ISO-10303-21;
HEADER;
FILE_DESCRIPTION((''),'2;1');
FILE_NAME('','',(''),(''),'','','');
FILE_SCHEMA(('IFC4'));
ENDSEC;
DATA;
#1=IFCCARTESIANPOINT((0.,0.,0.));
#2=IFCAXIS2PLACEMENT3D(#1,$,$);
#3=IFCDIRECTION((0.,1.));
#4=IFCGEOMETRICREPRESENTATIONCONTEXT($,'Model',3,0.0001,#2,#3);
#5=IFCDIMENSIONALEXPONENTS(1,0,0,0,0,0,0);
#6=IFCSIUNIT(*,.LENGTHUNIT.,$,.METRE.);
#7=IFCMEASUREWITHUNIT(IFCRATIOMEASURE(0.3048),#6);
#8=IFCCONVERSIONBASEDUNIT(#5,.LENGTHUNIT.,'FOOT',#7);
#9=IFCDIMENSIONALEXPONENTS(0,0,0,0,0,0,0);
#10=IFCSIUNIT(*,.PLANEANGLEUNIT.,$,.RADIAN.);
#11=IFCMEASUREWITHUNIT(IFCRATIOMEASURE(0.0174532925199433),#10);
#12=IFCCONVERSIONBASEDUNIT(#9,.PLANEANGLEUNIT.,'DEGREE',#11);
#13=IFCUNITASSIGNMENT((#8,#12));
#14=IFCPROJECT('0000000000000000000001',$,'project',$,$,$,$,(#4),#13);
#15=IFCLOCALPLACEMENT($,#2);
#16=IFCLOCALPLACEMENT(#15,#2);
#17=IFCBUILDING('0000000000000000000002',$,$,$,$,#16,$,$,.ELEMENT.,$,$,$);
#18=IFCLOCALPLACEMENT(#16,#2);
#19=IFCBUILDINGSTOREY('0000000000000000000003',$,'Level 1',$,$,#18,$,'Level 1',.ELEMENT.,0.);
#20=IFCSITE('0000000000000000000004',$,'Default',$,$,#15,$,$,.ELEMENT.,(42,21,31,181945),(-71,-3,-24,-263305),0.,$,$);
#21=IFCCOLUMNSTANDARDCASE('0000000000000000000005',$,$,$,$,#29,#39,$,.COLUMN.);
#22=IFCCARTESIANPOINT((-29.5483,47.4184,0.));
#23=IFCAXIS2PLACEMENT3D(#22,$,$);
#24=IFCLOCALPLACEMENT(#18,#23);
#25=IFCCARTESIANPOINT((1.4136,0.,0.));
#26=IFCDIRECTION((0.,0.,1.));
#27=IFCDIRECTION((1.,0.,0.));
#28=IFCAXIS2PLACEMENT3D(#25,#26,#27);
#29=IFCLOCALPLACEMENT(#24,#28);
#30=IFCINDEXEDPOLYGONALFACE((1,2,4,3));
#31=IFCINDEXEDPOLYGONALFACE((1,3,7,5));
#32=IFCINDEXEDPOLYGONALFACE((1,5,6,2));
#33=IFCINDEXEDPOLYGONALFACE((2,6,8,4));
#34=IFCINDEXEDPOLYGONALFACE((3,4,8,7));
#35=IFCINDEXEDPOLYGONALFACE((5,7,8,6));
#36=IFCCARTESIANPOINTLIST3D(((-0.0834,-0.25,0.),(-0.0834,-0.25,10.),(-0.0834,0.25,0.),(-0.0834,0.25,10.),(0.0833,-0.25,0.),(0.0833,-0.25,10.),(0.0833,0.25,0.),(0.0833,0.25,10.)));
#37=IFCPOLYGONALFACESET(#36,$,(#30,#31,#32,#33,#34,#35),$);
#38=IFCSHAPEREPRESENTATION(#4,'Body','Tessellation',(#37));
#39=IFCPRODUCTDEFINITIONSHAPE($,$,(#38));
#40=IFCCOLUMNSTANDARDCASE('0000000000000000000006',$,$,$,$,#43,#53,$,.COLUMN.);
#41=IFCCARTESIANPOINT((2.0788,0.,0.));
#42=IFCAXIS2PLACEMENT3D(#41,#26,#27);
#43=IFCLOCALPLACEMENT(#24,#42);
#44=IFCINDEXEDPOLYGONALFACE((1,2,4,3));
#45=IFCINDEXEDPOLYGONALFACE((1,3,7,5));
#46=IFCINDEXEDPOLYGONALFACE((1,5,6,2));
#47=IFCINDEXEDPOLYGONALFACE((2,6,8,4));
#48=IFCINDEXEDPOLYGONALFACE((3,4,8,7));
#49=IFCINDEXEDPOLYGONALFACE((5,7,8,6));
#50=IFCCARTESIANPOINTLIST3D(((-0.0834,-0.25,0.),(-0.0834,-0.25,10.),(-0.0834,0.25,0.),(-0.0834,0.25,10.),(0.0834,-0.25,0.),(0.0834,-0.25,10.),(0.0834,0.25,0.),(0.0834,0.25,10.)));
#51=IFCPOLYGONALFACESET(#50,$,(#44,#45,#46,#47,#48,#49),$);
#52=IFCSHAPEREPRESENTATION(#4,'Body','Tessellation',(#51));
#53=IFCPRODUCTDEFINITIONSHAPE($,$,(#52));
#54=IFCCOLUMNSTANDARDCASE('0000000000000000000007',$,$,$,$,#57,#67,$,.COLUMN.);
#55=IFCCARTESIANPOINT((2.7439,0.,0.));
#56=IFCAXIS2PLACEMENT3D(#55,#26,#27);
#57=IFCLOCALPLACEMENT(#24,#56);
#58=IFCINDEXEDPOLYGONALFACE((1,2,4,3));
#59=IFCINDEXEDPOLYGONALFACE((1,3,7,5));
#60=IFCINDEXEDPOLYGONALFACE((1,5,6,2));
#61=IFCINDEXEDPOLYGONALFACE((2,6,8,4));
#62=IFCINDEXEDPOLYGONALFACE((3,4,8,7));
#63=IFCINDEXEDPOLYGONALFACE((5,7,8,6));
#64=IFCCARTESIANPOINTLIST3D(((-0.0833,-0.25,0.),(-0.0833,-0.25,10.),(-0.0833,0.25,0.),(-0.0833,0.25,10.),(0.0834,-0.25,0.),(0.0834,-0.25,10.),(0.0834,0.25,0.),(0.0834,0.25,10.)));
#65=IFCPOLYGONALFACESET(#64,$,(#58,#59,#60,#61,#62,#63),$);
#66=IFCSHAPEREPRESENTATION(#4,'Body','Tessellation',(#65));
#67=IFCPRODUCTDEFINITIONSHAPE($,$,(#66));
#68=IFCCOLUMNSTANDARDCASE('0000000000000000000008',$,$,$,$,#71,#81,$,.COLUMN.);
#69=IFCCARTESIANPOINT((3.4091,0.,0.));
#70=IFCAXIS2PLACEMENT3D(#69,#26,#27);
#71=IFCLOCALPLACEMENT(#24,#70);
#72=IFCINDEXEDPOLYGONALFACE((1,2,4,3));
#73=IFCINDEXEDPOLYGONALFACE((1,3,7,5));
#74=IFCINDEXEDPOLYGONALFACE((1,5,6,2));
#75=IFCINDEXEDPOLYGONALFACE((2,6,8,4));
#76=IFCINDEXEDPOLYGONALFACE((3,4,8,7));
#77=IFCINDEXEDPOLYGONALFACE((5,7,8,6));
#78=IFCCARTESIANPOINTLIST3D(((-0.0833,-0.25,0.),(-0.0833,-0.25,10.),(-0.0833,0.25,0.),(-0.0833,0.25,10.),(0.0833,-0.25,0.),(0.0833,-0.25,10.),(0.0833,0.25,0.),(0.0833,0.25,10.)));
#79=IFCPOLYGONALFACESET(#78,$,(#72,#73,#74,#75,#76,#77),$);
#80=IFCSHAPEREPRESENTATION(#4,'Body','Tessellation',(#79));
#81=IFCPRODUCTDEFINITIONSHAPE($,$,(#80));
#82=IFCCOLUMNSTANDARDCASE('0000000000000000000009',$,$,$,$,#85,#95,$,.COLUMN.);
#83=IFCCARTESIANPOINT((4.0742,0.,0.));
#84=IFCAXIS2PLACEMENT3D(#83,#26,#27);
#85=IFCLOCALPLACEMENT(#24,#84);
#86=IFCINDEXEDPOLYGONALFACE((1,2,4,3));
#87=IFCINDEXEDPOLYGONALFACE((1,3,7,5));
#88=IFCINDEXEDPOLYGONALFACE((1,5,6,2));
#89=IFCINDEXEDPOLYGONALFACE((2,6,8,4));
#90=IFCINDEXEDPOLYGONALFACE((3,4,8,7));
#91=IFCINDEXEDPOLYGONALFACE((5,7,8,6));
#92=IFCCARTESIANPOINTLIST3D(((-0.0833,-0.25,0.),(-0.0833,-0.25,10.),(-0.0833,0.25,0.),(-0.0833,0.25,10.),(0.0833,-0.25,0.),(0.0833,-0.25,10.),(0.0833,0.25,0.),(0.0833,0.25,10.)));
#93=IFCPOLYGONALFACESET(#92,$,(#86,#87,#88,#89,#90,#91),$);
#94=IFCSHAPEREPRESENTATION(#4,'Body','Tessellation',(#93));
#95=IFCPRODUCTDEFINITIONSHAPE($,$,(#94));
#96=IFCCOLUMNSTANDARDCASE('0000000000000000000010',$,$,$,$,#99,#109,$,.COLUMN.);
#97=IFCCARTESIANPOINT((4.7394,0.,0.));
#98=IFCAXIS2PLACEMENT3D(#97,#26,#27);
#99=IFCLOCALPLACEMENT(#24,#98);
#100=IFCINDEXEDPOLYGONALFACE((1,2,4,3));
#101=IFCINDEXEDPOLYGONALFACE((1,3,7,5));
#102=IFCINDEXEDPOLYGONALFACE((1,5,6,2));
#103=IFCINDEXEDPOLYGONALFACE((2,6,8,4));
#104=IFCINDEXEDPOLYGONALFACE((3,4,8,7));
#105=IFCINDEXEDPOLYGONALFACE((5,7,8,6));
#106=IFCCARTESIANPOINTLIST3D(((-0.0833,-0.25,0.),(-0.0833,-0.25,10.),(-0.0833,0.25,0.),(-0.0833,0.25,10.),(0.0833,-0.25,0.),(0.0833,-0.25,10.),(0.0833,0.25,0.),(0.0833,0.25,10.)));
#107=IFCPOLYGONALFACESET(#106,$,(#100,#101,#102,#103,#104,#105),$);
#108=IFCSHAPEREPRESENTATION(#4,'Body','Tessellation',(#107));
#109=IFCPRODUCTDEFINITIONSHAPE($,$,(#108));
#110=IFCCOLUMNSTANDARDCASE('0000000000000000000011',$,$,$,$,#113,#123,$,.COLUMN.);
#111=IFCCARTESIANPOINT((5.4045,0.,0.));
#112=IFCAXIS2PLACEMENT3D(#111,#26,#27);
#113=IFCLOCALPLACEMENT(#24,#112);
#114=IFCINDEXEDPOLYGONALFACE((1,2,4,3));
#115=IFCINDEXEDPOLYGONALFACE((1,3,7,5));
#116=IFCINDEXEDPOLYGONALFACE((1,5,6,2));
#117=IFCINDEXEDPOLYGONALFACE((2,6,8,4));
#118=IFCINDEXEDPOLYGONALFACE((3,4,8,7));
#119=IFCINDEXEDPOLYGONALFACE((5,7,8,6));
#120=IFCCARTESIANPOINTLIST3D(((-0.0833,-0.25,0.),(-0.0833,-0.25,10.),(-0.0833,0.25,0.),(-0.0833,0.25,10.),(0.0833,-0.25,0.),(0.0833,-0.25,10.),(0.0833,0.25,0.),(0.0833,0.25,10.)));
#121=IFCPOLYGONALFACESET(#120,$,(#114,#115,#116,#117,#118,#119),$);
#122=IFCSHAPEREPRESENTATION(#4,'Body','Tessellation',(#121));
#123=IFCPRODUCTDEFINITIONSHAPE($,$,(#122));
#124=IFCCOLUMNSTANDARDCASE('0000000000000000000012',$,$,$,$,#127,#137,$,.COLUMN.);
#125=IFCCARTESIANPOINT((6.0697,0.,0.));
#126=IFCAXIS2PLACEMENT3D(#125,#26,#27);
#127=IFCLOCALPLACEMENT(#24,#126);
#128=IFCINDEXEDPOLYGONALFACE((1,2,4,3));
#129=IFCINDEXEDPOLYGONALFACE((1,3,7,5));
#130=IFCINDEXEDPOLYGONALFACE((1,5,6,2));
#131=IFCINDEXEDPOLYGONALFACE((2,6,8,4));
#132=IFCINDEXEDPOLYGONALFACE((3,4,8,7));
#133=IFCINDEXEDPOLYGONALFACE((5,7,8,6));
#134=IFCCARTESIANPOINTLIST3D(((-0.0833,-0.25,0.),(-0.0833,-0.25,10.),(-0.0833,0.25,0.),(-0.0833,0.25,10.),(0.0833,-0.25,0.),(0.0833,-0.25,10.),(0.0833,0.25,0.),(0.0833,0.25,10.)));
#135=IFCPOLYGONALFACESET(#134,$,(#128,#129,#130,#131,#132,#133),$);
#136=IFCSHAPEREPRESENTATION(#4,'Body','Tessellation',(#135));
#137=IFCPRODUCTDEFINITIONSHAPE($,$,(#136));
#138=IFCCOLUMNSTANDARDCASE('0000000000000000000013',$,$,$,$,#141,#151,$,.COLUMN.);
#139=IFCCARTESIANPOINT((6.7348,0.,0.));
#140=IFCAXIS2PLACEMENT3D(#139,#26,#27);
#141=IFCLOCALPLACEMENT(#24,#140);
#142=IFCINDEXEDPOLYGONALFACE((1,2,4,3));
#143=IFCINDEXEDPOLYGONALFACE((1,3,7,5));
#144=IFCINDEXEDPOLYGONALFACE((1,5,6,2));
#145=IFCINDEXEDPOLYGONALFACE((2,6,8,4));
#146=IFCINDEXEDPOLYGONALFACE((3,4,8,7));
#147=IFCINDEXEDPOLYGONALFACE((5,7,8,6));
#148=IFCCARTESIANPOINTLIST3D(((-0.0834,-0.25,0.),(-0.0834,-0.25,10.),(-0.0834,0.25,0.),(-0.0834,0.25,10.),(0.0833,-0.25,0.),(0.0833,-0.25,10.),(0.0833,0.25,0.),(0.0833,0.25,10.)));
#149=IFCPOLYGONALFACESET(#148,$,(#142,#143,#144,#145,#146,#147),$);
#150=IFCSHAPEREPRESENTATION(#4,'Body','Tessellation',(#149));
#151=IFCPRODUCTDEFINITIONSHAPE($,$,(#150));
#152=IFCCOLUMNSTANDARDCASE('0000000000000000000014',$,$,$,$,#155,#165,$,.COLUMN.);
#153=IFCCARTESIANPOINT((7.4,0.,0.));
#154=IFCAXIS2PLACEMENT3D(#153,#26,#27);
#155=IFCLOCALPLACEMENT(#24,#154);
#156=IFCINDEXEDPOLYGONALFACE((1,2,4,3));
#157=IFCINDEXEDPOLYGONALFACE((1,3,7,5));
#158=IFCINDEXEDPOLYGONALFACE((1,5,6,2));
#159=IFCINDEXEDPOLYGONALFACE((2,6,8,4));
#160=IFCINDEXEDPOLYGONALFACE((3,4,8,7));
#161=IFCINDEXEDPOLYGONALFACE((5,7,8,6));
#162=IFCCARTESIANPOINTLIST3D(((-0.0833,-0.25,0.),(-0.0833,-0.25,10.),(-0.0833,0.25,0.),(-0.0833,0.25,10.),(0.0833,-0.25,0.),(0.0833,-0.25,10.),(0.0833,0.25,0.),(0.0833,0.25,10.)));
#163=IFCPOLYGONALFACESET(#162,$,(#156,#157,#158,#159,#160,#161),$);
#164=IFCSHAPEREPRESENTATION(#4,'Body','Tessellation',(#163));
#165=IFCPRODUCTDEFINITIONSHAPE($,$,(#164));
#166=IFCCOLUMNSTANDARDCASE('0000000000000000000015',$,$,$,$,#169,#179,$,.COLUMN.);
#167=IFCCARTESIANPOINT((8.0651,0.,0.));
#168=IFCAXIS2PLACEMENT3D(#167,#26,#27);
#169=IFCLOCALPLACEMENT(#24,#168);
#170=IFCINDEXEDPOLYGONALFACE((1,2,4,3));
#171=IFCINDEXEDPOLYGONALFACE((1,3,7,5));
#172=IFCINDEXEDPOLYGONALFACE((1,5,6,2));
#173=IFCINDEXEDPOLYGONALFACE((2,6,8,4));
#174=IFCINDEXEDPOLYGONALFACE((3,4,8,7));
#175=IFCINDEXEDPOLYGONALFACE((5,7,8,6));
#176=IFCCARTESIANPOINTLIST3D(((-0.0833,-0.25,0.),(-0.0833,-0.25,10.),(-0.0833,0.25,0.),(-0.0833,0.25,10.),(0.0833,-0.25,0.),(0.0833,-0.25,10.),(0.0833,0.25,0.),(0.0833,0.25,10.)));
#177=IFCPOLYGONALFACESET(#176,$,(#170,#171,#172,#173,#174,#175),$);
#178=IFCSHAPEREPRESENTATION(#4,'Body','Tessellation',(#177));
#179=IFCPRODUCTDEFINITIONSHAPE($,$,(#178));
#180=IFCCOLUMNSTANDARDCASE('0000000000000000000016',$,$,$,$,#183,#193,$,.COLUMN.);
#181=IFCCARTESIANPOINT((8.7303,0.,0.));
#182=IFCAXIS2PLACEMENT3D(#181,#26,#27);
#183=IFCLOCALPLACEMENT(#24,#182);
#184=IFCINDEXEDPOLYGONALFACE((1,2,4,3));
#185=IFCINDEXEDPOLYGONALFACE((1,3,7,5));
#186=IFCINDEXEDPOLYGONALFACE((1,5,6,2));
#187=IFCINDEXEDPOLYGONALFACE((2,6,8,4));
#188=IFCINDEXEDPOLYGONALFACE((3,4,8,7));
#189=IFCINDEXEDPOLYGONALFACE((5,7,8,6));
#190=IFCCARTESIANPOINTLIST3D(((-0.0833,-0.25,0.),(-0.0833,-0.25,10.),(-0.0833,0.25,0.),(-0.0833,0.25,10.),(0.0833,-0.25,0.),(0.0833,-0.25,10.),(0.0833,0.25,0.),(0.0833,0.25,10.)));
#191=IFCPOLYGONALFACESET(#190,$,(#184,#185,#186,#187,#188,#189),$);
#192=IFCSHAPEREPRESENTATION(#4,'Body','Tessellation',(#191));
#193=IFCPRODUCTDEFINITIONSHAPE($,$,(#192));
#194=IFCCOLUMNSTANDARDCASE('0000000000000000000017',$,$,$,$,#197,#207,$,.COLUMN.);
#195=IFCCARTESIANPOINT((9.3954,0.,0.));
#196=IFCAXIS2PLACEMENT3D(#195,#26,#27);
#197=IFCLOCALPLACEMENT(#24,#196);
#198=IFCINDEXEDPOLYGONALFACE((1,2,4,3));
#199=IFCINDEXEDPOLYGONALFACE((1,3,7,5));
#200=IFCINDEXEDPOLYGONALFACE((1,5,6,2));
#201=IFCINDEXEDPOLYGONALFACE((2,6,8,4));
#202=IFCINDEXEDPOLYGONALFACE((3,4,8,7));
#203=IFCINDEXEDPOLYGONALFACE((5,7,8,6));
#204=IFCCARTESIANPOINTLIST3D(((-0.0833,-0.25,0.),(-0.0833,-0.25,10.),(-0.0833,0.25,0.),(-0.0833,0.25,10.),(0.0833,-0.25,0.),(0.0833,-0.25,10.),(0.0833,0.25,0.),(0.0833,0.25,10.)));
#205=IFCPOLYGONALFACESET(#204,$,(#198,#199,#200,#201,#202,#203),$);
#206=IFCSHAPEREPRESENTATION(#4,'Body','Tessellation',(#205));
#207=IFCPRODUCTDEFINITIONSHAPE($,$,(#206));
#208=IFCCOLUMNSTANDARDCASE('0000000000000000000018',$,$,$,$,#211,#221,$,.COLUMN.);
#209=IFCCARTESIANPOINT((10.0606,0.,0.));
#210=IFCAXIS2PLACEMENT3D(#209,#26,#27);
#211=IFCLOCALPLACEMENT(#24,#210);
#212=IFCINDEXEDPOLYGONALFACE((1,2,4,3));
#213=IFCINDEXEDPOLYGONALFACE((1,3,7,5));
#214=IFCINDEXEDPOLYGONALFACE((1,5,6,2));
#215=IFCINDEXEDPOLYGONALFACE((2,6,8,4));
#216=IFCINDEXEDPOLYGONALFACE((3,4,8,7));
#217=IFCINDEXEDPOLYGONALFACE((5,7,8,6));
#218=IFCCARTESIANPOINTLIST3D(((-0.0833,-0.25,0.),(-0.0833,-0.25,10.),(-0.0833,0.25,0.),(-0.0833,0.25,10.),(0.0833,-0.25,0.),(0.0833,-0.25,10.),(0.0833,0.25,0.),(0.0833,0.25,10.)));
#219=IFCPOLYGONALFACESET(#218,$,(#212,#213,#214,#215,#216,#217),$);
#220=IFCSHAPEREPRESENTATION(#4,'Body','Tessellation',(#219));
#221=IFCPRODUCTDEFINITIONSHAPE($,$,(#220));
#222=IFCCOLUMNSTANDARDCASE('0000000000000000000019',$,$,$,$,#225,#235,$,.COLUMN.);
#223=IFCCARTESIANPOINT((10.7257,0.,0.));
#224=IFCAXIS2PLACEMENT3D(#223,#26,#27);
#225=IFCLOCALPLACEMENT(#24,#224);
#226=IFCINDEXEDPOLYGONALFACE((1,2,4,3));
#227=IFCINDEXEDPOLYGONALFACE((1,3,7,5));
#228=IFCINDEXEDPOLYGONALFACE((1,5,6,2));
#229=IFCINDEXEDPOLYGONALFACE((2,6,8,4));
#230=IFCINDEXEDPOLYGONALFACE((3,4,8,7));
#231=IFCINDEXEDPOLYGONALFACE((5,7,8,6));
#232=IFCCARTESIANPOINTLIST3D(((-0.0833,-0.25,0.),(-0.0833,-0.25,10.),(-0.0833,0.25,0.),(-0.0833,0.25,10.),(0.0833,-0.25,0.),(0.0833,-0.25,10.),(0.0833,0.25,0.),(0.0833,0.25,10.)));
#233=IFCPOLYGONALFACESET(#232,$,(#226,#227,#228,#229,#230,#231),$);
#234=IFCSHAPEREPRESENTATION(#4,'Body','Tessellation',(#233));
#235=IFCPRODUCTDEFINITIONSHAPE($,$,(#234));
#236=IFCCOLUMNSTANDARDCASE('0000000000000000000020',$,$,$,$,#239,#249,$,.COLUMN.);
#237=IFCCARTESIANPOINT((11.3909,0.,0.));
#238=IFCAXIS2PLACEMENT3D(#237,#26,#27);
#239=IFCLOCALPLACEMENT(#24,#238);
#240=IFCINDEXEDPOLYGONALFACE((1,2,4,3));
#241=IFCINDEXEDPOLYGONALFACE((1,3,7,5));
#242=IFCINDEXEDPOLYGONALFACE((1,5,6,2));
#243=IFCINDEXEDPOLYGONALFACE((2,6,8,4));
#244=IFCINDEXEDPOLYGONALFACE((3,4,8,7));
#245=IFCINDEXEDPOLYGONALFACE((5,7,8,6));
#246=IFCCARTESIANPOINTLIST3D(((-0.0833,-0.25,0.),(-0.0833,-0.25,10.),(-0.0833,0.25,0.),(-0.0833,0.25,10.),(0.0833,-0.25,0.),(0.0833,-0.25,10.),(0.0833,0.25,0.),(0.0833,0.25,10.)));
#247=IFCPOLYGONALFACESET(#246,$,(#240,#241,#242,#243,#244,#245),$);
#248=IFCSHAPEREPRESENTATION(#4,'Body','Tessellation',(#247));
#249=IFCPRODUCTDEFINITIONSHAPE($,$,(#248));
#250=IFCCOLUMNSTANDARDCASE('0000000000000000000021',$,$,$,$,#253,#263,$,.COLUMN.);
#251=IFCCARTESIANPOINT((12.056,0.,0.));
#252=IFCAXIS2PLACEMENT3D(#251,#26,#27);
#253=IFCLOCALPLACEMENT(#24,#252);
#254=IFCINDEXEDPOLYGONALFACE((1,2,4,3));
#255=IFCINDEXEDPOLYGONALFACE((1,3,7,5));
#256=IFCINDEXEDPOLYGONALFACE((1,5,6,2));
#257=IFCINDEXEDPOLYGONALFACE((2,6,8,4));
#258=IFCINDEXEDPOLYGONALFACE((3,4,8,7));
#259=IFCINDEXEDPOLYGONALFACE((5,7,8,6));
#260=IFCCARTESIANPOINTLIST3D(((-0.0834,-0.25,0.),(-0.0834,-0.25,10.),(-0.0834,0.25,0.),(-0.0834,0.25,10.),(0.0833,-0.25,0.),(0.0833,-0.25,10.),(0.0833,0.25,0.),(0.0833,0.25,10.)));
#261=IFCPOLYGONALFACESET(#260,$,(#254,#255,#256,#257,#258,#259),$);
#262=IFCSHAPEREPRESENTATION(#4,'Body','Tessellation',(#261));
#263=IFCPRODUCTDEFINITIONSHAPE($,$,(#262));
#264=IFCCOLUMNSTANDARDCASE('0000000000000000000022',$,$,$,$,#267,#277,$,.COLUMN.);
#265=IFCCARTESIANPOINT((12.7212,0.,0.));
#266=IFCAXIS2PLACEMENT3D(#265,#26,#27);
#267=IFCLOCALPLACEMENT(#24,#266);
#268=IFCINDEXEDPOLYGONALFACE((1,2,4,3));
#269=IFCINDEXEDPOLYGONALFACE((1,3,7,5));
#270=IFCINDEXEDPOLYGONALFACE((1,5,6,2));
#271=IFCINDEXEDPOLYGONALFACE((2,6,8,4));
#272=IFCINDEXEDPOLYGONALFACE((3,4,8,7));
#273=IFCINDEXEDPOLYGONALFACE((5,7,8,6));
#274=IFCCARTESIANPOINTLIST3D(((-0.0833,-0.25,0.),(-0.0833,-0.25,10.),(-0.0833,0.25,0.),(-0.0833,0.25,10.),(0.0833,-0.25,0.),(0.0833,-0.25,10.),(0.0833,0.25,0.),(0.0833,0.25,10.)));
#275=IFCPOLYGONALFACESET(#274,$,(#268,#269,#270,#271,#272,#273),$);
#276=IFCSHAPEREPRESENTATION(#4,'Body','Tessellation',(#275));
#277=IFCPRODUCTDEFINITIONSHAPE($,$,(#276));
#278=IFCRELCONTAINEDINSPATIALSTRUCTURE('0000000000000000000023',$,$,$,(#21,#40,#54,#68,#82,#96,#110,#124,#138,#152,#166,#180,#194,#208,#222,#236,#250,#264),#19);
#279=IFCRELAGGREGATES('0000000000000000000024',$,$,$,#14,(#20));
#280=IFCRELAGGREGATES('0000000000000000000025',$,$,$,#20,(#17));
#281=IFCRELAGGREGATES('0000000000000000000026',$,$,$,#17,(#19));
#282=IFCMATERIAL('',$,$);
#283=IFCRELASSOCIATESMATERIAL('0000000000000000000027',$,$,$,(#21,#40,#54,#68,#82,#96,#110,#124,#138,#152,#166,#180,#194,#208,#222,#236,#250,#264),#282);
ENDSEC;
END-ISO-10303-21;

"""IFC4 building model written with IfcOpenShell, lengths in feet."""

from ifc_helpers import new_model, entity, si_unit, converted_unit, direction, frame, origin, place, context, project, spatial, rectangle, extrude, material, element, save


model = new_model("IFC4")

# Units and contexts
model_context = context("Model", 3, precision=0.0001, world=origin(), true_north=direction((0.0, 1.0)))
ifc_project = project(units=[converted_unit("LENGTHUNIT", "FOOT", entity("IfcRatioMeasure", 0.3048), si_unit("LENGTHUNIT", "METRE"), dimensions=[1, 0, 0, 0, 0, 0, 0]), converted_unit("PLANEANGLEUNIT", "DEGREE", entity("IfcRatioMeasure", 0.0174532925199433), si_unit("PLANEANGLEUNIT", "RADIAN"), dimensions=[0, 0, 0, 0, 0, 0, 0])], contexts=[model_context])

# Site, building, storey
site_placement = place(None, origin())
site = spatial("IfcSite", under=ifc_project, at=site_placement, Name="Default", CompositionType="ELEMENT", RefLatitude=(42, 21, 31, 181945), RefLongitude=(-71, -3, -24, -263305), RefElevation=0.0)
building_placement = place(site_placement, origin())
building = spatial("IfcBuilding", under=site, at=building_placement, CompositionType="ELEMENT")
storey_placement = place(building_placement, origin())
storey = spatial("IfcBuildingStorey", under=building, at=storey_placement, Name="Level 1", LongName="Level 1", CompositionType="ELEMENT", Elevation=0.0)

# Columns
ifc_material = material(Name="")
placement = place(storey_placement, frame((-29.5483, 47.4184, 0.0)))
for number, where, z_axis, x_axis in (
    (1, (1.4136, 0.0, 0.0), (0.0, 0.0, 1.0), (1.0, 0.0, 0.0)),
    (2, (2.0788, 0.0, 0.0), (0.0, 0.0, 1.0), (1.0, 0.0, 0.0)),
    (3, (2.7439, 0.0, 0.0), (0.0, 0.0, 1.0), (1.0, 0.0, 0.0)),
    (4, (3.4091, 0.0, 0.0), (0.0, 0.0, 1.0), (1.0, 0.0, 0.0)),
    (5, (4.0742, 0.0, 0.0), (0.0, 0.0, 1.0), (1.0, 0.0, 0.0)),
    (6, (4.7394, 0.0, 0.0), (0.0, 0.0, 1.0), (1.0, 0.0, 0.0)),
    (7, (5.4045, 0.0, 0.0), (0.0, 0.0, 1.0), (1.0, 0.0, 0.0)),
    (8, (6.0697, 0.0, 0.0), (0.0, 0.0, 1.0), (1.0, 0.0, 0.0)),
    (9, (6.7348, 0.0, 0.0), (0.0, 0.0, 1.0), (1.0, 0.0, 0.0)),
    (10, (7.4, 0.0, 0.0), (0.0, 0.0, 1.0), (1.0, 0.0, 0.0)),
    (11, (8.0651, 0.0, 0.0), (0.0, 0.0, 1.0), (1.0, 0.0, 0.0)),
    (12, (8.7303, 0.0, 0.0), (0.0, 0.0, 1.0), (1.0, 0.0, 0.0)),
    (13, (9.3954, 0.0, 0.0), (0.0, 0.0, 1.0), (1.0, 0.0, 0.0)),
    (14, (10.0606, 0.0, 0.0), (0.0, 0.0, 1.0), (1.0, 0.0, 0.0)),
    (15, (10.7257, 0.0, 0.0), (0.0, 0.0, 1.0), (1.0, 0.0, 0.0)),
    (16, (11.3909, 0.0, 0.0), (0.0, 0.0, 1.0), (1.0, 0.0, 0.0)),
    (17, (12.056, 0.0, 0.0), (0.0, 0.0, 1.0), (1.0, 0.0, 0.0)),
    (18, (12.7212, 0.0, 0.0), (0.0, 0.0, 1.0), (1.0, 0.0, 0.0)),
):
    element("IfcColumnStandardCase", number, at=place(placement, frame(where, z_axis=z_axis, x_axis=x_axis)), inside=storey, material=ifc_material, PredefinedType="COLUMN", context=model_context, shape_type="SweptSolid", body=[
        extrude(rectangle(XDim=0.1667, YDim=0.5), origin(), (0.0, 0.0, 1.0), 10.0),
    ])

save(model, "model.ifc")
